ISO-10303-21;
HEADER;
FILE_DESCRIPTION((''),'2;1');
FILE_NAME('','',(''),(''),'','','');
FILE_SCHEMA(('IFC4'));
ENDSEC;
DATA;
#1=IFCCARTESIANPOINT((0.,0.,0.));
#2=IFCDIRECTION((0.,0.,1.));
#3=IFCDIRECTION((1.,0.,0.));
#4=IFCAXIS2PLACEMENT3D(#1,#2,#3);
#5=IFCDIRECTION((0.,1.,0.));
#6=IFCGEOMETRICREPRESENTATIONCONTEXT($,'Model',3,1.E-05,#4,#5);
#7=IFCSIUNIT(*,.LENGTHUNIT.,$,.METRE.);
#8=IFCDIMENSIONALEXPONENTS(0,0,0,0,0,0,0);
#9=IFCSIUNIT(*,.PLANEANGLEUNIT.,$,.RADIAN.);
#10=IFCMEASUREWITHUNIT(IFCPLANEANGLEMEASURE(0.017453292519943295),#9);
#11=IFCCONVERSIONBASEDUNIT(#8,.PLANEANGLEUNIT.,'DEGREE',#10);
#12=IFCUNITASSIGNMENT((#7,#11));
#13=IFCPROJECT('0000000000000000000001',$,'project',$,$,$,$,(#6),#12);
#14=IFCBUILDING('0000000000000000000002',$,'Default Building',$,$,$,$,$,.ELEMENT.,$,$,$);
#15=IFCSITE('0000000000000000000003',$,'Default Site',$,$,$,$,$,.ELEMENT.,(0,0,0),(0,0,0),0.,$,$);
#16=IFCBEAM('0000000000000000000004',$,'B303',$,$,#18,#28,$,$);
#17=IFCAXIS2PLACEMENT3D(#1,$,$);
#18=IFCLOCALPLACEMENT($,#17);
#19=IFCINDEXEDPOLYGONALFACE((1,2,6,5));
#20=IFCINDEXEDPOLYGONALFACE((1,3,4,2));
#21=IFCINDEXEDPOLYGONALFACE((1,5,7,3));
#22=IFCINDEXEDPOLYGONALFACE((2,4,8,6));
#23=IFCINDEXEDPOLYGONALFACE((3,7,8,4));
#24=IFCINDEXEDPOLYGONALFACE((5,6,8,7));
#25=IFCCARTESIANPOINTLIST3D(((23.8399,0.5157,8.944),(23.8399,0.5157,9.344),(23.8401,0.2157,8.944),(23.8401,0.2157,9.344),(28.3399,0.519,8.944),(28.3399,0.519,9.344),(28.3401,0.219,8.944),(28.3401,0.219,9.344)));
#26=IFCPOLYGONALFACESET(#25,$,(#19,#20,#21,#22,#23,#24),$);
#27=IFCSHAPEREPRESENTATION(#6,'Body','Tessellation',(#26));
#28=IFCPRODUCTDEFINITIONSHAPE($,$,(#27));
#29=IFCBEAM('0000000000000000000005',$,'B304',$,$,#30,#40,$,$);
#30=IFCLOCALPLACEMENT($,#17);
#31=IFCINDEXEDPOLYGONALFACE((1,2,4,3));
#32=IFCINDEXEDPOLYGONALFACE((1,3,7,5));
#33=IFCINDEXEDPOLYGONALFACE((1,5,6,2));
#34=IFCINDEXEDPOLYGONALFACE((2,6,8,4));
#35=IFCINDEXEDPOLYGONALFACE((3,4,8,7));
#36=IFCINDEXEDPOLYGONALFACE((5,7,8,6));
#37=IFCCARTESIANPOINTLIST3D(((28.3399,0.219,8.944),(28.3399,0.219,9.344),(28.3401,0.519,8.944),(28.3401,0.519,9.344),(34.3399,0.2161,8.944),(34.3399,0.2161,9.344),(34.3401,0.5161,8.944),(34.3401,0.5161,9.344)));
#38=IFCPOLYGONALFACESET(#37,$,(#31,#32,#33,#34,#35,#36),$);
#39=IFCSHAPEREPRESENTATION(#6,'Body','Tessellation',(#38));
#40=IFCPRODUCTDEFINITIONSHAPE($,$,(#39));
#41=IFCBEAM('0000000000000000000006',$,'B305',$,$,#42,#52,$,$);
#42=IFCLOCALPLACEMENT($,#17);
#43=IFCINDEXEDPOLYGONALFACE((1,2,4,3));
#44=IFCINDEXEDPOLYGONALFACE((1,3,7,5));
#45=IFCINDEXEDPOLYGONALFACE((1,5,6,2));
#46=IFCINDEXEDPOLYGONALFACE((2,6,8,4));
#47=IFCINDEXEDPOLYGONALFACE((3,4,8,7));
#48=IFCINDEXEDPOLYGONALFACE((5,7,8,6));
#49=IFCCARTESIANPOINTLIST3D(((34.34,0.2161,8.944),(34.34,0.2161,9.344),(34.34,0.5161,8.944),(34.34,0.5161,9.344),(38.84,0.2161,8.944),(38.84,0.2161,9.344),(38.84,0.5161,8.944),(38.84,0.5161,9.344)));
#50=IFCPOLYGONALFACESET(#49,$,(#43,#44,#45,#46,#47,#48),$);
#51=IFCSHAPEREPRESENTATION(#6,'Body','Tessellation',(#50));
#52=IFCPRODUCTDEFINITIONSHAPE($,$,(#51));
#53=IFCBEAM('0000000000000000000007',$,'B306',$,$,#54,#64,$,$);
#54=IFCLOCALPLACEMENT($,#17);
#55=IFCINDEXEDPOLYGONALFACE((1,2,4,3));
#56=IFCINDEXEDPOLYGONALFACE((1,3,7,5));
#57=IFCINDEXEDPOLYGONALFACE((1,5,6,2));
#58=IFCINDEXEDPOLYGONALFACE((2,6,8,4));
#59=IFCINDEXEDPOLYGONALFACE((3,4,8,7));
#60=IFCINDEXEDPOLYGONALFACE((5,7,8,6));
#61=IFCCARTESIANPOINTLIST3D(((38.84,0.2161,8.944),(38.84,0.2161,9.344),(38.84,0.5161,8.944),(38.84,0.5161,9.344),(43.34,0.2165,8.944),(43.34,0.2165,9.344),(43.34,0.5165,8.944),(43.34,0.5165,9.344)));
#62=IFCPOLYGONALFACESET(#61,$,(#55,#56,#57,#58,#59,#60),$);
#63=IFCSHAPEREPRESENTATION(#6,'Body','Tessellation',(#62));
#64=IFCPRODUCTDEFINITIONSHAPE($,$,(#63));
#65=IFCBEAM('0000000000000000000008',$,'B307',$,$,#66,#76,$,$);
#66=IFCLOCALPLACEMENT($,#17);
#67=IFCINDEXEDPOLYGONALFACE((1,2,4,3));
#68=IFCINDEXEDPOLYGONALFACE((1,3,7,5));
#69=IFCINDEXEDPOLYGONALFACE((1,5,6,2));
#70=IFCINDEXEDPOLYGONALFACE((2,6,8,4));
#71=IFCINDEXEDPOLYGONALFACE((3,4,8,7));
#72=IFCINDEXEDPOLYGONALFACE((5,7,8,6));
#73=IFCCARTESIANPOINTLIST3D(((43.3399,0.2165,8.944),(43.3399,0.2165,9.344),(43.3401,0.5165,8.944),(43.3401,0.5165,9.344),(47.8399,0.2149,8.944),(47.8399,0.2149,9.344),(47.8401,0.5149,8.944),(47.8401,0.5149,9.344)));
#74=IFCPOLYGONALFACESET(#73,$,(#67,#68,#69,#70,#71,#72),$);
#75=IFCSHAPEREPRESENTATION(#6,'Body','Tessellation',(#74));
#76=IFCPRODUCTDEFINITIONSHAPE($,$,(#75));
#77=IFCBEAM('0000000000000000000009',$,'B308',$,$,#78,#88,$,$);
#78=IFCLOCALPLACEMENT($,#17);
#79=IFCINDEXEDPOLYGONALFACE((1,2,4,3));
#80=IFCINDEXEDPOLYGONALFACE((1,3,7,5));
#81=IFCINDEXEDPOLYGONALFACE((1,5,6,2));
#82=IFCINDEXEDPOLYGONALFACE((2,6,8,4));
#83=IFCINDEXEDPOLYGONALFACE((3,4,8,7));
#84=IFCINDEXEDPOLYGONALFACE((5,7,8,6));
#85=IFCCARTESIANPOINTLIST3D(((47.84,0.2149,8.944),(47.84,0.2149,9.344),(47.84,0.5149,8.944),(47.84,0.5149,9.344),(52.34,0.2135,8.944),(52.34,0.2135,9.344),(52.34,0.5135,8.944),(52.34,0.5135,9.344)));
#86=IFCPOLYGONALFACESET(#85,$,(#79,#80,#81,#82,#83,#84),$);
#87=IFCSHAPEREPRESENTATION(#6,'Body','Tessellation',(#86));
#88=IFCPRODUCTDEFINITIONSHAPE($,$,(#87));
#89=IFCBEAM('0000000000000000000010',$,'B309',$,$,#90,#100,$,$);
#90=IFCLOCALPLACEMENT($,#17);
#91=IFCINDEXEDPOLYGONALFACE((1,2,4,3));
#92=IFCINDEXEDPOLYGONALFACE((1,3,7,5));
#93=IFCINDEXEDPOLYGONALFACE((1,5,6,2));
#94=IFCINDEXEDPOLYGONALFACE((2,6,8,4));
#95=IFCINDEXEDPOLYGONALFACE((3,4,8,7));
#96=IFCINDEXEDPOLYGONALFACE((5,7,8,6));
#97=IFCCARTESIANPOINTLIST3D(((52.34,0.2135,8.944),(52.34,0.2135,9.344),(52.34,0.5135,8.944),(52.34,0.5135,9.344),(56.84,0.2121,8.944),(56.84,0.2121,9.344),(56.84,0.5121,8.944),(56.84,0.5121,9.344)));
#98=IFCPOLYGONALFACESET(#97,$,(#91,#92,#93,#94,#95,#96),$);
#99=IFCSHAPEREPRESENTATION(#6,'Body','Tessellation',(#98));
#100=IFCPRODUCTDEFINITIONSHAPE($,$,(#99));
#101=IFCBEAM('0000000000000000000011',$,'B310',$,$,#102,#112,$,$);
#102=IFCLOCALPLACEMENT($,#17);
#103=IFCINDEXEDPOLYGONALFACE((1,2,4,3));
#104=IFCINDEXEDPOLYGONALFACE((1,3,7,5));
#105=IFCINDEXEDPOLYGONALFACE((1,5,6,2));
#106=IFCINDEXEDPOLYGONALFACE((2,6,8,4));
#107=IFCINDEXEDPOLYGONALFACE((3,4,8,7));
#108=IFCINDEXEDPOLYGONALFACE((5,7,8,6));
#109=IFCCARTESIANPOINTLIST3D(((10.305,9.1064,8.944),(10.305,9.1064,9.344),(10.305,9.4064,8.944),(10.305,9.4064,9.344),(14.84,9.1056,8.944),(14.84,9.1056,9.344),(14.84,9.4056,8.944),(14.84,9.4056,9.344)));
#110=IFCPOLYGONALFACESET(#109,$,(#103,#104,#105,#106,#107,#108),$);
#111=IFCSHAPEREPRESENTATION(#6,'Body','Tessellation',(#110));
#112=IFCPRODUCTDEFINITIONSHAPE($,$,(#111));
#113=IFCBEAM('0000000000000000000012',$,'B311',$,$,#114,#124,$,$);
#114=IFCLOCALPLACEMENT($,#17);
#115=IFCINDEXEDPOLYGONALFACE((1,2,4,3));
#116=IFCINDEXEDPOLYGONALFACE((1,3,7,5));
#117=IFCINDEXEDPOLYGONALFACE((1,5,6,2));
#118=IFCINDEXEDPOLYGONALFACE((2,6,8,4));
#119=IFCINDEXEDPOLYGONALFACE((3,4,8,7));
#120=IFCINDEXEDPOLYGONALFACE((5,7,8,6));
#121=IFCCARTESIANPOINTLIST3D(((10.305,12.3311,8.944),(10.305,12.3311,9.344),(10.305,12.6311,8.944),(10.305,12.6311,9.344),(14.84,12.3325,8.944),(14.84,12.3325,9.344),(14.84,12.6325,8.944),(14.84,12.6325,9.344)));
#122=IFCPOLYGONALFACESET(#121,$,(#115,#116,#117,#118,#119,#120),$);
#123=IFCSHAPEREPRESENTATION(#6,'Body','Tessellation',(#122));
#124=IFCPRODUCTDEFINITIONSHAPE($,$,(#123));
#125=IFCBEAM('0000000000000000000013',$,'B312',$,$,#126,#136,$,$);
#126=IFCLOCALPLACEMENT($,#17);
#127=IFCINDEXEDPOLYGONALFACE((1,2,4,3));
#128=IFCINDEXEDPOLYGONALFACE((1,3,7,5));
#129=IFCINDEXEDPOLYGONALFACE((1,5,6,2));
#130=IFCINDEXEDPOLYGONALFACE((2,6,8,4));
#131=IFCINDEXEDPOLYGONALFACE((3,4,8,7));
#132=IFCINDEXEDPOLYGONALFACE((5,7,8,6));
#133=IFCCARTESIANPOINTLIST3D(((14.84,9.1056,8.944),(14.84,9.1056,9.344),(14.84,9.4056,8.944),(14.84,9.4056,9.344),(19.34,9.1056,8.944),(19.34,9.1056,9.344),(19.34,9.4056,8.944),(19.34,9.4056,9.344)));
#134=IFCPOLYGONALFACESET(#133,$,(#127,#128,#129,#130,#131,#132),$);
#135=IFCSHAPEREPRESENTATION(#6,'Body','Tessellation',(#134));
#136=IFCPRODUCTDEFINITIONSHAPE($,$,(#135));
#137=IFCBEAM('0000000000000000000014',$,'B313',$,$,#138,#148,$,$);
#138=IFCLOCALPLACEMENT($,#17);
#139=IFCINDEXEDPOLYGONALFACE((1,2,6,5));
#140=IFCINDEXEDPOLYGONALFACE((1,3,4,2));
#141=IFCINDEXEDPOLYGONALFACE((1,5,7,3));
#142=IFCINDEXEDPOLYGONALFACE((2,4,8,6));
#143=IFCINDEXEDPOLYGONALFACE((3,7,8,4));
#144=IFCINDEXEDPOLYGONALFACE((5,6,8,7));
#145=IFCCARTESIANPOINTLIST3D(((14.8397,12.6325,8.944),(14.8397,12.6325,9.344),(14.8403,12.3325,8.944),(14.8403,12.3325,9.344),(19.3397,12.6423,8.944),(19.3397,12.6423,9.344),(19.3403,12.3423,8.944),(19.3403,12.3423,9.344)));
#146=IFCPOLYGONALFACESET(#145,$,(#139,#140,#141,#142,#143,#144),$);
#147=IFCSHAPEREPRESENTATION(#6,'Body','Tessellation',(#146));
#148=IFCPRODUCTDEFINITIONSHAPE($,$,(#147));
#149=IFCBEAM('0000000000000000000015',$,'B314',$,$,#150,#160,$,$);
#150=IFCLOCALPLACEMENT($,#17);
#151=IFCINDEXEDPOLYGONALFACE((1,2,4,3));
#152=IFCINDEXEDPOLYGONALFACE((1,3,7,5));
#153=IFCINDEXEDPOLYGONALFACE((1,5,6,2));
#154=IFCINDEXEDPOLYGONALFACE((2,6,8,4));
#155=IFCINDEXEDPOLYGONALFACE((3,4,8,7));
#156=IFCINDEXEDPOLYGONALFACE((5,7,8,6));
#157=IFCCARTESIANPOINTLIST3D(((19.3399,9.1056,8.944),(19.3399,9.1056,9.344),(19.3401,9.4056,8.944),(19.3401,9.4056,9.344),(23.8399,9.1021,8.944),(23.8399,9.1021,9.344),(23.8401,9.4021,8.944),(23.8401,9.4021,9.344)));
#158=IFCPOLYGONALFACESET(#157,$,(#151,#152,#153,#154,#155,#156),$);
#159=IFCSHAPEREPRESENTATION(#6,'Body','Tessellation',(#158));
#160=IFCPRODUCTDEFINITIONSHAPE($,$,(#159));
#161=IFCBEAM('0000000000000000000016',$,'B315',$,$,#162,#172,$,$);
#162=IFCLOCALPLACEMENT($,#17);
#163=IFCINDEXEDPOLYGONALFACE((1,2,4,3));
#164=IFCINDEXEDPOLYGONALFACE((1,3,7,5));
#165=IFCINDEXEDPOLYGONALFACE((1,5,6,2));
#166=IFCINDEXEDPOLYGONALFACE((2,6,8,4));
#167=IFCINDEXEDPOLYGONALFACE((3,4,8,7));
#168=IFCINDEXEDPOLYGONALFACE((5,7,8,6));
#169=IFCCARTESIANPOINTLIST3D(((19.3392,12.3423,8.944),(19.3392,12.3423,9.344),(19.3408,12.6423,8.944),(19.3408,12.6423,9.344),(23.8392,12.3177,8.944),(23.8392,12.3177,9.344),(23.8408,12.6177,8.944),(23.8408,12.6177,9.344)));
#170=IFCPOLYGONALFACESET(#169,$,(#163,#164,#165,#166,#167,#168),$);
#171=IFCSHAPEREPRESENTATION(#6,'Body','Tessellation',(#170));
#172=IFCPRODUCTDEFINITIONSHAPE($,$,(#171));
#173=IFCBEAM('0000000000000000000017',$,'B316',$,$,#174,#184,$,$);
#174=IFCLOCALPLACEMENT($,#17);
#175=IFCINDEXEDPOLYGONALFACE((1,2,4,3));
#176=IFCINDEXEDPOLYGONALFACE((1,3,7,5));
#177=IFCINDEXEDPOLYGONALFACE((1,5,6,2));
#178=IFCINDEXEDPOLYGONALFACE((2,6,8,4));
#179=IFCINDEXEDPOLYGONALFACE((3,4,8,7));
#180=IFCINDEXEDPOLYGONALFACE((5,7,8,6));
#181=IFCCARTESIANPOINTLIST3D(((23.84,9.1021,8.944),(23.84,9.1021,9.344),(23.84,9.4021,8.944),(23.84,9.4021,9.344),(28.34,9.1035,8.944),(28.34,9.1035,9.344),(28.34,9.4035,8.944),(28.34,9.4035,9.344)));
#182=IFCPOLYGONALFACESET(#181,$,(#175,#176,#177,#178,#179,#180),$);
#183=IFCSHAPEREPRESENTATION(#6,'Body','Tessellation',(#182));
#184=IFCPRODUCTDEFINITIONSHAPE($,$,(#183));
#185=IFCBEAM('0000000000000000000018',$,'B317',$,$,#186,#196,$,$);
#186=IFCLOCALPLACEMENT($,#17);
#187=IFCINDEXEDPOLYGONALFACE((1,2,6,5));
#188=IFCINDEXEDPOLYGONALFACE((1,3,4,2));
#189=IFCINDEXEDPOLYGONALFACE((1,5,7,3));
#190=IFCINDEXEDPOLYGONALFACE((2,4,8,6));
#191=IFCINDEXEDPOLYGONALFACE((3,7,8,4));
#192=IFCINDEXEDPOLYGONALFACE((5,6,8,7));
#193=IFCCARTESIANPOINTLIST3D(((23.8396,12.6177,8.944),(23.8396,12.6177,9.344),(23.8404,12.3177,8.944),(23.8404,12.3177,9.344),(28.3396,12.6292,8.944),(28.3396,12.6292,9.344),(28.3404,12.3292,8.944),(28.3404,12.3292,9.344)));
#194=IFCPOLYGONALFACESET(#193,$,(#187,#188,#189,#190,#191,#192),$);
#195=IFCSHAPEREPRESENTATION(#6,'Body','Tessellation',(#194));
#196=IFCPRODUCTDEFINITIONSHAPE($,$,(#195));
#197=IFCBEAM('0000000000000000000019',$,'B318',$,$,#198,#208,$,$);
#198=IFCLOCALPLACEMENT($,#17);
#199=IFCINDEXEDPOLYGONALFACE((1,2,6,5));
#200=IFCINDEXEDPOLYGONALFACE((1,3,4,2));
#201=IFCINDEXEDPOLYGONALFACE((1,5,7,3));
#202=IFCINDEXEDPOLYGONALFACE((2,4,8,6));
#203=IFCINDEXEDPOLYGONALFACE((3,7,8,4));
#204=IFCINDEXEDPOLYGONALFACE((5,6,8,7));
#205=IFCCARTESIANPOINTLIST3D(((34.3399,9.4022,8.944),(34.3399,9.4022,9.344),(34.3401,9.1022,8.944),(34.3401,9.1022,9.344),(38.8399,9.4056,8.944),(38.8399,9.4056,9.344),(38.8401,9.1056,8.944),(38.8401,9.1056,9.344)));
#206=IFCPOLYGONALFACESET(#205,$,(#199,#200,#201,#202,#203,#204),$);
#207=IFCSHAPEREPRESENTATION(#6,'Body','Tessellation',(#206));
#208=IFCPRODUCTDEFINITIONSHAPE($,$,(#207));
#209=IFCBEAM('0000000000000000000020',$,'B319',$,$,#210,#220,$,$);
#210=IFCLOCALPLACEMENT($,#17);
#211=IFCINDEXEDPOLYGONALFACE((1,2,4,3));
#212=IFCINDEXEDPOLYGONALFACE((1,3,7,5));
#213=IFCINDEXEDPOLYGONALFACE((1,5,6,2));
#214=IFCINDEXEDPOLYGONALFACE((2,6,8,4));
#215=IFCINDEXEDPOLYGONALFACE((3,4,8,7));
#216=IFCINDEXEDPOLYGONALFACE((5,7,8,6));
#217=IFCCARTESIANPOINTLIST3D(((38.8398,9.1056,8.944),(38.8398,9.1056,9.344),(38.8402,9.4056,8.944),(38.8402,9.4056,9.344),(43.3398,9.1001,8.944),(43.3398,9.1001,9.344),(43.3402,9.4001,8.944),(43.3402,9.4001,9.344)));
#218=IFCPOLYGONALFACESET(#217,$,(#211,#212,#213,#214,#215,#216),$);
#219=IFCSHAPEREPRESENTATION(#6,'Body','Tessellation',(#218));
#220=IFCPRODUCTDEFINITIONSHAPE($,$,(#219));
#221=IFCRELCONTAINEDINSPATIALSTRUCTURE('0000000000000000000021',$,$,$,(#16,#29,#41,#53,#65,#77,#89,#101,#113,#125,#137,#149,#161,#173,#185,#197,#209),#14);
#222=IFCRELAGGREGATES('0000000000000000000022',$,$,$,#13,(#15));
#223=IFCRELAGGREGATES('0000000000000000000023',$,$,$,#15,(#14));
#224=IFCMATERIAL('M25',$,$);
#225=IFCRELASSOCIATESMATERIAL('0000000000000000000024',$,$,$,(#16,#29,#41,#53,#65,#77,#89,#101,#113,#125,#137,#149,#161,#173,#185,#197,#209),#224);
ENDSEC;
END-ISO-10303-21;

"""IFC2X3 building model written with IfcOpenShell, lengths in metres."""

from ifc_helpers import new_model, entity, si_unit, converted_unit, direction, frame, frame_2d, origin_with_axes, place, context, project, spatial, rectangle, extrude, material, element, save


model = new_model("IFC2X3")

# Units and contexts
model_context = context("Model", 3, precision=1e-05, world=origin_with_axes(), true_north=direction((0.0, 1.0, 0.0)))
ifc_project = project(units=[si_unit("LENGTHUNIT", "METRE"), converted_unit("PLANEANGLEUNIT", "DEGREE", entity("IfcPlaneAngleMeasure", 0.017453292519943295), si_unit("PLANEANGLEUNIT", "RADIAN"), dimensions=[0, 0, 0, 0, 0, 0, 0])], contexts=[model_context])

# Site, building
site = spatial("IfcSite", under=ifc_project, Name="Default Site", CompositionType="ELEMENT", RefLatitude=(0, 0, 0), RefLongitude=(0, 0, 0), RefElevation=0.0)
building = spatial("IfcBuilding", under=site, Name="Default Building", CompositionType="ELEMENT")

# Beams
ifc_material = material(Name="M25")
placement = place(None, origin_with_axes())
element("IfcBeam", 1, at=placement, inside=building, material=ifc_material, Name="B303", context=model_context, shape_type="SweptSolid", body=[
    extrude(rectangle(XDim=0.3, YDim=0.4, at=frame_2d((0.0, 0.0), x_axis=(0.0, 1.0, 0.0))), frame((23.84, 0.3657, 9.144), z_axis=(1.0, 0.00075, 0.0), x_axis=(0.0, 0.0, -1.0)), (0.0, 0.0, 1.0), 4.5),
])
element("IfcBeam", 2, at=placement, inside=building, material=ifc_material, Name="B304", context=model_context, shape_type="SweptSolid", body=[
    extrude(rectangle(XDim=0.3, YDim=0.4, at=frame_2d((0.0, 0.0), x_axis=(0.0, 1.0, 0.0))), frame((28.34, 0.369, 9.144), z_axis=(1.0, -0.000487, 0.0), x_axis=(0.0, 0.0, -1.0)), (0.0, 0.0, 1.0), 6.0),
])
element("IfcBeam", 3, at=placement, inside=building, material=ifc_material, Name="B305", context=model_context, shape_type="SweptSolid", body=[
    extrude(rectangle(XDim=0.3, YDim=0.4, at=frame_2d((0.0, 0.0), x_axis=(0.0, 1.0, 0.0))), frame((34.34, 0.3661, 9.144), z_axis=(1.0, 0.000003, 0.0), x_axis=(0.0, 0.0, -1.0)), (0.0, 0.0, 1.0), 4.5),
])
element("IfcBeam", 4, at=placement, inside=building, material=ifc_material, Name="B306", context=model_context, shape_type="SweptSolid", body=[
    extrude(rectangle(XDim=0.3, YDim=0.4, at=frame_2d((0.0, 0.0), x_axis=(0.0, 1.0, 0.0))), frame((38.84, 0.3661, 9.144), z_axis=(1.0, 0.000077, 0.0), x_axis=(0.0, 0.0, -1.0)), (0.0, 0.0, 1.0), 4.5),
])
element("IfcBeam", 5, at=placement, inside=building, material=ifc_material, Name="B307", context=model_context, shape_type="SweptSolid", body=[
    extrude(rectangle(XDim=0.3, YDim=0.4, at=frame_2d((0.0, 0.0), x_axis=(0.0, 1.0, 0.0))), frame((43.34, 0.3665, 9.144), z_axis=(1.0, -0.000358, 0.0), x_axis=(0.0, 0.0, -1.0)), (0.0, 0.0, 1.0), 4.5),
])
element("IfcBeam", 6, at=placement, inside=building, material=ifc_material, Name="B308", context=model_context, shape_type="SweptSolid", body=[
    extrude(rectangle(XDim=0.3, YDim=0.4, at=frame_2d((0.0, 0.0), x_axis=(0.0, 1.0, 0.0))), frame((47.84, 0.3649, 9.144), z_axis=(1.0, -0.000297, 0.0), x_axis=(0.0, 0.0, -1.0)), (0.0, 0.0, 1.0), 4.5),
])
element("IfcBeam", 7, at=placement, inside=building, material=ifc_material, Name="B309", context=model_context, shape_type="SweptSolid", body=[
    extrude(rectangle(XDim=0.3, YDim=0.4, at=frame_2d((0.0, 0.0), x_axis=(0.0, 1.0, 0.0))), frame((52.34, 0.3635, 9.144), z_axis=(1.0, -0.000311, 0.0), x_axis=(0.0, 0.0, -1.0)), (0.0, 0.0, 1.0), 4.5),
])
element("IfcBeam", 8, at=placement, inside=building, material=ifc_material, Name="B310", context=model_context, shape_type="SweptSolid", body=[
    extrude(rectangle(XDim=0.3, YDim=0.4, at=frame_2d((0.0, 0.0), x_axis=(0.0, 1.0, 0.0))), frame((10.305, 9.2564, 9.144), z_axis=(1.0, -0.000182, 0.0), x_axis=(0.0, 0.0, -1.0)), (0.0, 0.0, 1.0), 4.535),
])
element("IfcBeam", 9, at=placement, inside=building, material=ifc_material, Name="B311", context=model_context, shape_type="SweptSolid", body=[
    extrude(rectangle(XDim=0.3, YDim=0.4, at=frame_2d((0.0, 0.0), x_axis=(0.0, 1.0, 0.0))), frame((10.305, 12.4811, 9.144), z_axis=(1.0, 0.000301, 0.0), x_axis=(0.0, 0.0, -1.0)), (0.0, 0.0, 1.0), 4.535),
])
element("IfcBeam", 10, at=placement, inside=building, material=ifc_material, Name="B312", context=model_context, shape_type="SweptSolid", body=[
    extrude(rectangle(XDim=0.3, YDim=0.4, at=frame_2d((0.0, 0.0), x_axis=(0.0, 1.0, 0.0))), frame((14.84, 9.2556, 9.144), z_axis=(1.0, 0.000013, 0.0), x_axis=(0.0, 0.0, -1.0)), (0.0, 0.0, 1.0), 4.5),
])
element("IfcBeam", 11, at=placement, inside=building, material=ifc_material, Name="B313", context=model_context, shape_type="SweptSolid", body=[
    extrude(rectangle(XDim=0.3, YDim=0.4, at=frame_2d((0.0, 0.0), x_axis=(0.0, 1.0, 0.0))), frame((14.84, 12.4825, 9.144), z_axis=(0.999998, 0.002176, 0.0), x_axis=(0.0, 0.0, -1.0)), (0.0, 0.0, 1.0), 4.5),
])
element("IfcBeam", 12, at=placement, inside=building, material=ifc_material, Name="B314", context=model_context, shape_type="SweptSolid", body=[
    extrude(rectangle(XDim=0.3, YDim=0.4, at=frame_2d((0.0, 0.0), x_axis=(0.0, 1.0, 0.0))), frame((19.34, 9.2556, 9.144), z_axis=(1.0, -0.000779, 0.0), x_axis=(0.0, 0.0, -1.0)), (0.0, 0.0, 1.0), 4.5),
])
element("IfcBeam", 13, at=placement, inside=building, material=ifc_material, Name="B315", context=model_context, shape_type="SweptSolid", body=[
    extrude(rectangle(XDim=0.3, YDim=0.4, at=frame_2d((0.0, 0.0), x_axis=(0.0, 1.0, 0.0))), frame((19.34, 12.4923, 9.144), z_axis=(0.999985, -0.005463, 0.0), x_axis=(0.0, 0.0, -1.0)), (0.0, 0.0, 1.0), 4.5001),
])
element("IfcBeam", 14, at=placement, inside=building, material=ifc_material, Name="B316", context=model_context, shape_type="SweptSolid", body=[
    extrude(rectangle(XDim=0.3, YDim=0.4, at=frame_2d((0.0, 0.0), x_axis=(0.0, 1.0, 0.0))), frame((23.84, 9.2521, 9.144), z_axis=(1.0, 0.000307, 0.0), x_axis=(0.0, 0.0, -1.0)), (0.0, 0.0, 1.0), 4.5),
])
element("IfcBeam", 15, at=placement, inside=building, material=ifc_material, Name="B317", context=model_context, shape_type="SweptSolid", body=[
    extrude(rectangle(XDim=0.3, YDim=0.4, at=frame_2d((0.0, 0.0), x_axis=(0.0, 1.0, 0.0))), frame((23.84, 12.4677, 9.144), z_axis=(0.999997, 0.002551, 0.0), x_axis=(0.0, 0.0, -1.0)), (0.0, 0.0, 1.0), 4.5),
])
element("IfcBeam", 16, at=placement, inside=building, material=ifc_material, Name="B318", context=model_context, shape_type="SweptSolid", body=[
    extrude(rectangle(XDim=0.3, YDim=0.4, at=frame_2d((0.0, 0.0), x_axis=(0.0, 1.0, 0.0))), frame((34.34, 9.2522, 9.144), z_axis=(1.0, 0.000748, 0.0), x_axis=(0.0, 0.0, -1.0)), (0.0, 0.0, 1.0), 4.5),
])
element("IfcBeam", 17, at=placement, inside=building, material=ifc_material, Name="B319", context=model_context, shape_type="SweptSolid", body=[
    extrude(rectangle(XDim=0.3, YDim=0.4, at=frame_2d((0.0, 0.0), x_axis=(0.0, 1.0, 0.0))), frame((38.84, 9.2556, 9.144), z_axis=(0.999999, -0.001227, 0.0), x_axis=(0.0, 0.0, -1.0)), (0.0, 0.0, 1.0), 4.5),
])

save(model, "model.ifc")
